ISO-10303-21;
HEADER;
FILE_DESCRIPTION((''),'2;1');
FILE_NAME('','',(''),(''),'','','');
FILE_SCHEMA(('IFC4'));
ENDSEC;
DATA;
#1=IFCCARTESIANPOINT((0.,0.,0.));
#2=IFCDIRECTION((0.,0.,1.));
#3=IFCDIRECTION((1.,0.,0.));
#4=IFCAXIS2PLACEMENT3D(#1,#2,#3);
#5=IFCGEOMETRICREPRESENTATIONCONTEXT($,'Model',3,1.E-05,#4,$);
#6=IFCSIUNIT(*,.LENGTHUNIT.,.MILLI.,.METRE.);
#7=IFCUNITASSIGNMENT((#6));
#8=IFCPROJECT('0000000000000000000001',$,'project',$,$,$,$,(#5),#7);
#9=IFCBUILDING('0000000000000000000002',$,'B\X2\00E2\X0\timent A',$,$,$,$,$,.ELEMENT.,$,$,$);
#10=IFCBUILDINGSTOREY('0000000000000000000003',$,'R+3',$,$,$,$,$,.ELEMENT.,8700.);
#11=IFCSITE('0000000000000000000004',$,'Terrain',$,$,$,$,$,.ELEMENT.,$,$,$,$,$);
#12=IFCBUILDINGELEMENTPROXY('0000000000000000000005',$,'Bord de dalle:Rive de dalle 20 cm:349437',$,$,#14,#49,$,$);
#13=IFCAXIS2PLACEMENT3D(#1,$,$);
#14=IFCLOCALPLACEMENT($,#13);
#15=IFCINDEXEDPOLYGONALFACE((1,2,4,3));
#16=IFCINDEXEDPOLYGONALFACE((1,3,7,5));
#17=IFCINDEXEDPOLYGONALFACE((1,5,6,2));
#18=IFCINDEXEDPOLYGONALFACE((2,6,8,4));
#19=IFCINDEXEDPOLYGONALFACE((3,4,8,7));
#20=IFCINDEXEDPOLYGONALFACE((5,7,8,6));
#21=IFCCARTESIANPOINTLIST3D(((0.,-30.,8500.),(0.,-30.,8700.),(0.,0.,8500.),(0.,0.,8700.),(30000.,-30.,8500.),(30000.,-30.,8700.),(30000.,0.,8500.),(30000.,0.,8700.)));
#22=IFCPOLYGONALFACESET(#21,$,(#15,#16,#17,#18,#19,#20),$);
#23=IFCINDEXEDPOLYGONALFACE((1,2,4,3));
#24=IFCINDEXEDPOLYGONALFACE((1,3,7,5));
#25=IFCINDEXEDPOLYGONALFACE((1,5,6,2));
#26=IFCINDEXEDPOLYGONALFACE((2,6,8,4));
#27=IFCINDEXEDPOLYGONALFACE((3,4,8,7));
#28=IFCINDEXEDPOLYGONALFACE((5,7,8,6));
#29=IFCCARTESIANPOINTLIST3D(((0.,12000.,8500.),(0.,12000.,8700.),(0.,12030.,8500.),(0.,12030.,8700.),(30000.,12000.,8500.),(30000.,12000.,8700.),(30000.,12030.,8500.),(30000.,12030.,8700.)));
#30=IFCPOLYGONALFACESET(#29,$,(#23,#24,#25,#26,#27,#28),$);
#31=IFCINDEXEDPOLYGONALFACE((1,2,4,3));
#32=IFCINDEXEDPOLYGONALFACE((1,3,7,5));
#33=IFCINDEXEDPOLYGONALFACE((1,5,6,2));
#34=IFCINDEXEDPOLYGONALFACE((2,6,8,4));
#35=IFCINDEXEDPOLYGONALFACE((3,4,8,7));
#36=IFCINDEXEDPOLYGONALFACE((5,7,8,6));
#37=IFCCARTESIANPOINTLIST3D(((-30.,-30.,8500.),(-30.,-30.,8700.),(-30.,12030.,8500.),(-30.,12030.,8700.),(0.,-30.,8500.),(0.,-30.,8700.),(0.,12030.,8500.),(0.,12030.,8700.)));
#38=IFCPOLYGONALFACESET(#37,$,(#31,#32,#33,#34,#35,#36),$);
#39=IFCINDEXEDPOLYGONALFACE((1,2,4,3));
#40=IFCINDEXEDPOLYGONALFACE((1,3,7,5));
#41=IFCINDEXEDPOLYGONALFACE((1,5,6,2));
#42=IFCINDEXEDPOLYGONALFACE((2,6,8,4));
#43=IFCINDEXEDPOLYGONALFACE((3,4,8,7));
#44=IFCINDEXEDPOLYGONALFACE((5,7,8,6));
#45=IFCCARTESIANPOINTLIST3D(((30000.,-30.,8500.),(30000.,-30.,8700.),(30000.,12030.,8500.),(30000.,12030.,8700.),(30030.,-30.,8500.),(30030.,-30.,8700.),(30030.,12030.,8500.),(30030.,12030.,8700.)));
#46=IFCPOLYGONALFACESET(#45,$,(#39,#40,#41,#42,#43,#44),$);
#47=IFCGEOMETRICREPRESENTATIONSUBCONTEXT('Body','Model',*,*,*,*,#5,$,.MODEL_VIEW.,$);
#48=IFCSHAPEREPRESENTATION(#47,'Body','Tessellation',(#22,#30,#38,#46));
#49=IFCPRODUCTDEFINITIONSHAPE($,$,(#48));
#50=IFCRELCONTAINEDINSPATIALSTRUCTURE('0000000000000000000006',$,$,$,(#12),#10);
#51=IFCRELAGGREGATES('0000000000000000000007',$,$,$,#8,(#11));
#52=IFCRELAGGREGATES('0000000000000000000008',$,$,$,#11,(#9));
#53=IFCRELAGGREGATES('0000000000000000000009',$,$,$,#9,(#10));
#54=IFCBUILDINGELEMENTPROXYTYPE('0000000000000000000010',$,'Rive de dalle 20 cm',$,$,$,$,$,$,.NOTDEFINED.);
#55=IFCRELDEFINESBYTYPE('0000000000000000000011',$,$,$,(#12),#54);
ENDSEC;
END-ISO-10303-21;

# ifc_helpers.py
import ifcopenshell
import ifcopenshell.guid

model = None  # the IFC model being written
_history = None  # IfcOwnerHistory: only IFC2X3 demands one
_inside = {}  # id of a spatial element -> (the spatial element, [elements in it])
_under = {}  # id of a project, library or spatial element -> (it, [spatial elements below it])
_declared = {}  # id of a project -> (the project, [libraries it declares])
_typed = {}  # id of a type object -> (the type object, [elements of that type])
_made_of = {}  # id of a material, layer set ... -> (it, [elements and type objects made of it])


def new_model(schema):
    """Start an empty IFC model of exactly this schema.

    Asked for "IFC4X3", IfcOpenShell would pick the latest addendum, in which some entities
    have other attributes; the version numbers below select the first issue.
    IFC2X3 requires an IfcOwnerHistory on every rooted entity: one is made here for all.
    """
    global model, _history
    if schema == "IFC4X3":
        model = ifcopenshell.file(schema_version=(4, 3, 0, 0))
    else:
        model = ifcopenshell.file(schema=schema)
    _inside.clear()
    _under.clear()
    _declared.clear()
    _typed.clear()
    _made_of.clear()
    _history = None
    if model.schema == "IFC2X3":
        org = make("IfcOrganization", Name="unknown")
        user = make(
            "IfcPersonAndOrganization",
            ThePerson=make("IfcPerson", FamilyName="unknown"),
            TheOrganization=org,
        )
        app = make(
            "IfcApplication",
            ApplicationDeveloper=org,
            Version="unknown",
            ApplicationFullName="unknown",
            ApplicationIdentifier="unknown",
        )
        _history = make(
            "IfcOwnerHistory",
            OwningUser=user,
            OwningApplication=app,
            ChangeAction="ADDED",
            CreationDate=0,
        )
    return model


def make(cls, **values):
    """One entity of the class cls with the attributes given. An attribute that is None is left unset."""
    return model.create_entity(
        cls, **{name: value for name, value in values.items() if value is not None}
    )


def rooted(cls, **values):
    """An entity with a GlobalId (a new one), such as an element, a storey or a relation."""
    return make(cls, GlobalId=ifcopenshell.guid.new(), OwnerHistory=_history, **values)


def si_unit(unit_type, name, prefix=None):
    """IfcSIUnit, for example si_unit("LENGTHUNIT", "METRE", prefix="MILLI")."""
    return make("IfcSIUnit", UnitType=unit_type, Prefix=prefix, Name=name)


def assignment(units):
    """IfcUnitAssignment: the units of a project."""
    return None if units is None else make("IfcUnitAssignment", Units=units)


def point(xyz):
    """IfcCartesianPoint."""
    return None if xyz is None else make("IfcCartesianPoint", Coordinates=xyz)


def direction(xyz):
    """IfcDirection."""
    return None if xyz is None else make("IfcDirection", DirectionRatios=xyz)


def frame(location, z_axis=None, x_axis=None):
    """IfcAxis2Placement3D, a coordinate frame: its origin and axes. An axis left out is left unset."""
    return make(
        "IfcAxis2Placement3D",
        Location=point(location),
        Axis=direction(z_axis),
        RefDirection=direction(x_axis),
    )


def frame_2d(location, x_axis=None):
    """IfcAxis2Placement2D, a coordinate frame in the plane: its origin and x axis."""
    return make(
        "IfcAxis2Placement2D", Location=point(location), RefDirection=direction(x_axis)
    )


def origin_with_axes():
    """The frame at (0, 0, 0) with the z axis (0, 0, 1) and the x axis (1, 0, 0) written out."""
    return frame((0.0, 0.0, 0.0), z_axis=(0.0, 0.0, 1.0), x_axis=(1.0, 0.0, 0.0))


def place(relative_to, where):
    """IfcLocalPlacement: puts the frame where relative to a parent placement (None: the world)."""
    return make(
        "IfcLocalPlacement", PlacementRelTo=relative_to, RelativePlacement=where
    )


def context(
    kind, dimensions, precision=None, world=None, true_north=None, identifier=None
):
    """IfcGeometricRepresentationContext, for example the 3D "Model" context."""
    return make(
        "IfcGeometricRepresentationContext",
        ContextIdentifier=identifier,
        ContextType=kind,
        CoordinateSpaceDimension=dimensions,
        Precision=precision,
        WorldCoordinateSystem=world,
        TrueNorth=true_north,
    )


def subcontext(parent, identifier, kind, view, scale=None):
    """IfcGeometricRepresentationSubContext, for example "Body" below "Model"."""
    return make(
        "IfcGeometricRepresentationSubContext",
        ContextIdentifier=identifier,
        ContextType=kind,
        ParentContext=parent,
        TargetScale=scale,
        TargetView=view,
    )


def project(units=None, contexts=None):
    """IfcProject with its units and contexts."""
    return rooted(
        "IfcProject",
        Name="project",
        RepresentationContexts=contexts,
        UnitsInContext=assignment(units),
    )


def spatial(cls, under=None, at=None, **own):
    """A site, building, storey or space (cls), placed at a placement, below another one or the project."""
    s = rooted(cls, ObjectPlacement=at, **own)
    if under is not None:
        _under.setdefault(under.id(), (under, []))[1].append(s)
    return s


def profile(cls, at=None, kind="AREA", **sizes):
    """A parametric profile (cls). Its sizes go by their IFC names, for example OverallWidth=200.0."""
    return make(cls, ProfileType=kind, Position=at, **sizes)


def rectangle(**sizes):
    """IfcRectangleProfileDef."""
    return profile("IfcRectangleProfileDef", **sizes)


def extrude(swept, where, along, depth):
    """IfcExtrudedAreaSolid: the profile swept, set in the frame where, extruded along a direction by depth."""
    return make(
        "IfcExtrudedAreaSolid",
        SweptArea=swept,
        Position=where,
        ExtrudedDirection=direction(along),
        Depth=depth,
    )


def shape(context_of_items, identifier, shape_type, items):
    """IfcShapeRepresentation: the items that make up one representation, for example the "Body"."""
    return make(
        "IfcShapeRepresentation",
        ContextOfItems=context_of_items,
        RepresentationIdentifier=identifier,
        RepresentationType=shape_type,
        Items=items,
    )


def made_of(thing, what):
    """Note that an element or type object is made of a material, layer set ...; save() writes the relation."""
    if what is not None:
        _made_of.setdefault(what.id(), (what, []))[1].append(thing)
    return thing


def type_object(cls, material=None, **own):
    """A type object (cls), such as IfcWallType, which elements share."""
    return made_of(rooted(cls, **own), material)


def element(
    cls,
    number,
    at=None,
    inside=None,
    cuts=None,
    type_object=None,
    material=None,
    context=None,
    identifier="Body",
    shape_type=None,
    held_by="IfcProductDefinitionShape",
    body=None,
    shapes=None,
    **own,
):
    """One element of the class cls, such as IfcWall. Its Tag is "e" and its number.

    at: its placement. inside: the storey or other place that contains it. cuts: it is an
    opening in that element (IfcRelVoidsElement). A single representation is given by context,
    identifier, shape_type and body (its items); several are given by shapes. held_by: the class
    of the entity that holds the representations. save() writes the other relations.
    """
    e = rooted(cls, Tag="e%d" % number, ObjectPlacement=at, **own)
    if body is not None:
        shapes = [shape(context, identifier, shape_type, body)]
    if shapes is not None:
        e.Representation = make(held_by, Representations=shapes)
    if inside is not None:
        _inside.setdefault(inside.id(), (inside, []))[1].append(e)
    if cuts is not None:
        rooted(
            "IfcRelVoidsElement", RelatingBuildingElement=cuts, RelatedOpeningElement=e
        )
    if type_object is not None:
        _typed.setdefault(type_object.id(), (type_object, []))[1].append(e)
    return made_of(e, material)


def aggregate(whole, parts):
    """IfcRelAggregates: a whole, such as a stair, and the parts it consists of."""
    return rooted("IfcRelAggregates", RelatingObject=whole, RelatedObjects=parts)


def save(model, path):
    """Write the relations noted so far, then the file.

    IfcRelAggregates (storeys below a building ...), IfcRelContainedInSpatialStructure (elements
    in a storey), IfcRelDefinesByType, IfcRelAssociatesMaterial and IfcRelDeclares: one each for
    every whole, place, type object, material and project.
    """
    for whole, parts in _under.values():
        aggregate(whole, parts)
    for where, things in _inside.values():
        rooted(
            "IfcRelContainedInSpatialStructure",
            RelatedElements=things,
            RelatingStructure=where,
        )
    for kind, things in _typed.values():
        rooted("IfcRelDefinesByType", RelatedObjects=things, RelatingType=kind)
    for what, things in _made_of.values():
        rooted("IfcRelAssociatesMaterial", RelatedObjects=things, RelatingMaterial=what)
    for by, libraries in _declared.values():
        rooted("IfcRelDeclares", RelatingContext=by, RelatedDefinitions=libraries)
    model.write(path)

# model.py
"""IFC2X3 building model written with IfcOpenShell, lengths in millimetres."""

from ifc_helpers import new_model, si_unit, frame, frame_2d, origin_with_axes, place, context, subcontext, project, spatial, rectangle, extrude, type_object, element, save


model = new_model("IFC2X3")

# Units and contexts
model_context = context("Model", 3, precision=1e-05, world=origin_with_axes())
body_context = subcontext(model_context, "Body", "Model", "MODEL_VIEW")
ifc_project = project(units=[si_unit("LENGTHUNIT", "METRE", prefix="MILLI")], contexts=[model_context])

# Site, building, storey
site = spatial("IfcSite", under=ifc_project, Name="Terrain", CompositionType="ELEMENT")
building = spatial("IfcBuilding", under=site, Name="Bâtiment A", CompositionType="ELEMENT")
storey = spatial("IfcBuildingStorey", under=building, Name="R+3", CompositionType="ELEMENT", Elevation=8700.0)

# Building element proxy
building_element_proxy_type = type_object("IfcBuildingElementProxyType", Name="Rive de dalle 20 cm", PredefinedType="NOTDEFINED")
proxy_placement = place(None, origin_with_axes())
element("IfcBuildingElementProxy", 1, at=proxy_placement, inside=storey, type_object=building_element_proxy_type, Name="Bord de dalle:Rive de dalle 20 cm:349437", context=body_context, shape_type="SweptSolid", body=[
    extrude(rectangle(XDim=30000.0, YDim=30.0, at=frame_2d((15000.0, -15.0))), frame((0.0, 0.0, 8500.0), z_axis=(0.0, 0.0, 1.0), x_axis=(1.0, 0.0, 0.0)), (0.0, 0.0, 1.0), 200.0),
    extrude(rectangle(XDim=30000.0, YDim=30.0, at=frame_2d((15000.0, 12015.0))), frame((0.0, 0.0, 8500.0), z_axis=(0.0, 0.0, 1.0), x_axis=(1.0, 0.0, 0.0)), (0.0, 0.0, 1.0), 200.0),
    extrude(rectangle(XDim=30.0, YDim=12060.0, at=frame_2d((-15.0, 6000.0))), frame((0.0, 0.0, 8500.0), z_axis=(0.0, 0.0, 1.0), x_axis=(1.0, 0.0, 0.0)), (0.0, 0.0, 1.0), 200.0),
    extrude(rectangle(XDim=30.0, YDim=12060.0, at=frame_2d((30015.0, 6000.0))), frame((0.0, 0.0, 8500.0), z_axis=(0.0, 0.0, 1.0), x_axis=(1.0, 0.0, 0.0)), (0.0, 0.0, 1.0), 200.0),
])

save(model, "model.ifc")
